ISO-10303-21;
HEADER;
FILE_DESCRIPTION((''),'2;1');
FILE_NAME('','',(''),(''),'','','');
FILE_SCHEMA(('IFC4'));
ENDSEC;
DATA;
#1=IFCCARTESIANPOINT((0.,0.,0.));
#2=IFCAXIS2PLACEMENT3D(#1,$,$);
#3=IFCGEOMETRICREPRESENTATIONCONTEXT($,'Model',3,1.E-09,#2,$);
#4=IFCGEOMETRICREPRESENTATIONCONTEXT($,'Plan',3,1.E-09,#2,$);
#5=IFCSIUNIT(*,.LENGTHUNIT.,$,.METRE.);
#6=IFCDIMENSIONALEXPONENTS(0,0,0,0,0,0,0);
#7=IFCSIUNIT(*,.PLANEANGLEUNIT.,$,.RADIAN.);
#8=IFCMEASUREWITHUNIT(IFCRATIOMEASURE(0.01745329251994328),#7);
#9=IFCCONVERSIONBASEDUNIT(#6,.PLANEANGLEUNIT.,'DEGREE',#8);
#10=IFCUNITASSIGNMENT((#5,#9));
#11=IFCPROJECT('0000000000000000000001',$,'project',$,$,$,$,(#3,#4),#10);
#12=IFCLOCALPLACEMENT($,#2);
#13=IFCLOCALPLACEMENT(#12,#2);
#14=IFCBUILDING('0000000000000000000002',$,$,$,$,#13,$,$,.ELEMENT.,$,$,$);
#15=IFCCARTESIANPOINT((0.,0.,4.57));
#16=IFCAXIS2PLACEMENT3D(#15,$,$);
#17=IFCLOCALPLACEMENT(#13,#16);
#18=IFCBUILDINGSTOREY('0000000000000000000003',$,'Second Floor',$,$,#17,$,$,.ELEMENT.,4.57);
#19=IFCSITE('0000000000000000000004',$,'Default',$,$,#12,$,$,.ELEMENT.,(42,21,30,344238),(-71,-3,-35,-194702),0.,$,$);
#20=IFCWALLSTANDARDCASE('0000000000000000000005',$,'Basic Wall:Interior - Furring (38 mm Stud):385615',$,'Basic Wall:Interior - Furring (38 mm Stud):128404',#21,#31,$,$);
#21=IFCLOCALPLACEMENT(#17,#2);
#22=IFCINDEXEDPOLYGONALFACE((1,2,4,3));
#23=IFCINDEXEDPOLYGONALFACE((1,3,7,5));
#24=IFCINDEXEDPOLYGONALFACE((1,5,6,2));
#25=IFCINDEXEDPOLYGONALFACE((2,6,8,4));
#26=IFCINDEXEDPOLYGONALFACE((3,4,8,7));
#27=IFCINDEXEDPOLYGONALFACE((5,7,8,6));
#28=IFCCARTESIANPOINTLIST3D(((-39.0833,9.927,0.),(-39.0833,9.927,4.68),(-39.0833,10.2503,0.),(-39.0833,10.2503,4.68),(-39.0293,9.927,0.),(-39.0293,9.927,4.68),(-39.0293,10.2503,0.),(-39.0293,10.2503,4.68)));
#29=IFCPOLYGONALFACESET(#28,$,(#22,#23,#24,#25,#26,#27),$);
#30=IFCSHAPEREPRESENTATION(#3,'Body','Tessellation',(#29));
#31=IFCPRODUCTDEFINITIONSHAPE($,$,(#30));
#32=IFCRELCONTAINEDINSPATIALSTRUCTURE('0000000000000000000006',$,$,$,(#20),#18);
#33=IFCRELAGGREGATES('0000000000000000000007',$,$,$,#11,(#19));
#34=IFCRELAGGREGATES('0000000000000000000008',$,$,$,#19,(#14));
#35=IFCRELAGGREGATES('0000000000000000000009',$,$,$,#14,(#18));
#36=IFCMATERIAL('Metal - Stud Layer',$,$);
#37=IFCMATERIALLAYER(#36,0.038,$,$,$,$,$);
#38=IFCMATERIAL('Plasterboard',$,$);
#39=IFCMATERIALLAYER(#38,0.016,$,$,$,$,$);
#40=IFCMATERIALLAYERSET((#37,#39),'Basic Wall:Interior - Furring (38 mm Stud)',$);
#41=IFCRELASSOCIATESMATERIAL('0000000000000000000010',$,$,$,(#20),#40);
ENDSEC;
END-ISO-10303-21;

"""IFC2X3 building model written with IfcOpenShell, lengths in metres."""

from ifc_helpers import new_model, entity, si_unit, converted_unit, frame, frame_2d, origin, place, context, project, spatial, rectangle, extrude, material, layer, layer_set, layer_usage, element, save


model = new_model("IFC2X3")

# Units and contexts
model_context = context("Model", 3, precision=1e-09, world=origin())
plan_context = context("Plan", 3, precision=1e-09, world=origin())
ifc_project = project(units=[si_unit("LENGTHUNIT", "METRE"), converted_unit("PLANEANGLEUNIT", "DEGREE", entity("IfcRatioMeasure", 0.01745329251994328), si_unit("PLANEANGLEUNIT", "RADIAN"), dimensions=[0, 0, 0, 0, 0, 0, 0])], contexts=[model_context, plan_context])

# Site, building, storey
site_placement = place(None, origin())
site = spatial("IfcSite", under=ifc_project, at=site_placement, Name="Default", CompositionType="ELEMENT", RefLatitude=(42, 21, 30, 344238), RefLongitude=(-71, -3, -35, -194702), RefElevation=0.0)
building_placement = place(site_placement, origin())
building = spatial("IfcBuilding", under=site, at=building_placement, CompositionType="ELEMENT")
storey_placement = place(building_placement, frame((0.0, 0.0, 4.57)))
storey = spatial("IfcBuildingStorey", under=building, at=storey_placement, Name="Second Floor", CompositionType="ELEMENT", Elevation=4.57)

# Shared definitions
ifc_material_1 = material(Name="Plasterboard")
ifc_material_2 = material(Name="Metal - Stud Layer")

# Wall
ifc_layer_1 = layer(ifc_material_2, 0.038)
ifc_layer_2 = layer(ifc_material_1, 0.016)
ifc_layer_set_1 = layer_set([ifc_layer_1, ifc_layer_2], Name="Basic Wall:Interior - Furring (38 mm Stud)")
ifc_layer_usage_1 = layer_usage(ifc_layer_set_1, "AXIS2", "NEGATIVE", 0.027)
wall_1_placement = place(storey_placement, frame((-39.0563, 10.2503, 0.0), z_axis=(0.0, 0.0, 1.0), x_axis=(0.0, -1.0, 0.0)))
element("IfcWallStandardCase", 1, at=wall_1_placement, inside=storey, material=ifc_layer_usage_1, Name="Basic Wall:Interior - Furring (38 mm Stud):385615", ObjectType="Basic Wall:Interior - Furring (38 mm Stud):128404", context=model_context, shape_type="SweptSolid", body=[
    extrude(rectangle(XDim=0.3233, YDim=0.054, at=frame_2d((0.1617, 0.0), x_axis=(-1.0, 0.0))), origin(), (0.0, 0.0, 1.0), 4.68),
])

save(model, "model.ifc")
